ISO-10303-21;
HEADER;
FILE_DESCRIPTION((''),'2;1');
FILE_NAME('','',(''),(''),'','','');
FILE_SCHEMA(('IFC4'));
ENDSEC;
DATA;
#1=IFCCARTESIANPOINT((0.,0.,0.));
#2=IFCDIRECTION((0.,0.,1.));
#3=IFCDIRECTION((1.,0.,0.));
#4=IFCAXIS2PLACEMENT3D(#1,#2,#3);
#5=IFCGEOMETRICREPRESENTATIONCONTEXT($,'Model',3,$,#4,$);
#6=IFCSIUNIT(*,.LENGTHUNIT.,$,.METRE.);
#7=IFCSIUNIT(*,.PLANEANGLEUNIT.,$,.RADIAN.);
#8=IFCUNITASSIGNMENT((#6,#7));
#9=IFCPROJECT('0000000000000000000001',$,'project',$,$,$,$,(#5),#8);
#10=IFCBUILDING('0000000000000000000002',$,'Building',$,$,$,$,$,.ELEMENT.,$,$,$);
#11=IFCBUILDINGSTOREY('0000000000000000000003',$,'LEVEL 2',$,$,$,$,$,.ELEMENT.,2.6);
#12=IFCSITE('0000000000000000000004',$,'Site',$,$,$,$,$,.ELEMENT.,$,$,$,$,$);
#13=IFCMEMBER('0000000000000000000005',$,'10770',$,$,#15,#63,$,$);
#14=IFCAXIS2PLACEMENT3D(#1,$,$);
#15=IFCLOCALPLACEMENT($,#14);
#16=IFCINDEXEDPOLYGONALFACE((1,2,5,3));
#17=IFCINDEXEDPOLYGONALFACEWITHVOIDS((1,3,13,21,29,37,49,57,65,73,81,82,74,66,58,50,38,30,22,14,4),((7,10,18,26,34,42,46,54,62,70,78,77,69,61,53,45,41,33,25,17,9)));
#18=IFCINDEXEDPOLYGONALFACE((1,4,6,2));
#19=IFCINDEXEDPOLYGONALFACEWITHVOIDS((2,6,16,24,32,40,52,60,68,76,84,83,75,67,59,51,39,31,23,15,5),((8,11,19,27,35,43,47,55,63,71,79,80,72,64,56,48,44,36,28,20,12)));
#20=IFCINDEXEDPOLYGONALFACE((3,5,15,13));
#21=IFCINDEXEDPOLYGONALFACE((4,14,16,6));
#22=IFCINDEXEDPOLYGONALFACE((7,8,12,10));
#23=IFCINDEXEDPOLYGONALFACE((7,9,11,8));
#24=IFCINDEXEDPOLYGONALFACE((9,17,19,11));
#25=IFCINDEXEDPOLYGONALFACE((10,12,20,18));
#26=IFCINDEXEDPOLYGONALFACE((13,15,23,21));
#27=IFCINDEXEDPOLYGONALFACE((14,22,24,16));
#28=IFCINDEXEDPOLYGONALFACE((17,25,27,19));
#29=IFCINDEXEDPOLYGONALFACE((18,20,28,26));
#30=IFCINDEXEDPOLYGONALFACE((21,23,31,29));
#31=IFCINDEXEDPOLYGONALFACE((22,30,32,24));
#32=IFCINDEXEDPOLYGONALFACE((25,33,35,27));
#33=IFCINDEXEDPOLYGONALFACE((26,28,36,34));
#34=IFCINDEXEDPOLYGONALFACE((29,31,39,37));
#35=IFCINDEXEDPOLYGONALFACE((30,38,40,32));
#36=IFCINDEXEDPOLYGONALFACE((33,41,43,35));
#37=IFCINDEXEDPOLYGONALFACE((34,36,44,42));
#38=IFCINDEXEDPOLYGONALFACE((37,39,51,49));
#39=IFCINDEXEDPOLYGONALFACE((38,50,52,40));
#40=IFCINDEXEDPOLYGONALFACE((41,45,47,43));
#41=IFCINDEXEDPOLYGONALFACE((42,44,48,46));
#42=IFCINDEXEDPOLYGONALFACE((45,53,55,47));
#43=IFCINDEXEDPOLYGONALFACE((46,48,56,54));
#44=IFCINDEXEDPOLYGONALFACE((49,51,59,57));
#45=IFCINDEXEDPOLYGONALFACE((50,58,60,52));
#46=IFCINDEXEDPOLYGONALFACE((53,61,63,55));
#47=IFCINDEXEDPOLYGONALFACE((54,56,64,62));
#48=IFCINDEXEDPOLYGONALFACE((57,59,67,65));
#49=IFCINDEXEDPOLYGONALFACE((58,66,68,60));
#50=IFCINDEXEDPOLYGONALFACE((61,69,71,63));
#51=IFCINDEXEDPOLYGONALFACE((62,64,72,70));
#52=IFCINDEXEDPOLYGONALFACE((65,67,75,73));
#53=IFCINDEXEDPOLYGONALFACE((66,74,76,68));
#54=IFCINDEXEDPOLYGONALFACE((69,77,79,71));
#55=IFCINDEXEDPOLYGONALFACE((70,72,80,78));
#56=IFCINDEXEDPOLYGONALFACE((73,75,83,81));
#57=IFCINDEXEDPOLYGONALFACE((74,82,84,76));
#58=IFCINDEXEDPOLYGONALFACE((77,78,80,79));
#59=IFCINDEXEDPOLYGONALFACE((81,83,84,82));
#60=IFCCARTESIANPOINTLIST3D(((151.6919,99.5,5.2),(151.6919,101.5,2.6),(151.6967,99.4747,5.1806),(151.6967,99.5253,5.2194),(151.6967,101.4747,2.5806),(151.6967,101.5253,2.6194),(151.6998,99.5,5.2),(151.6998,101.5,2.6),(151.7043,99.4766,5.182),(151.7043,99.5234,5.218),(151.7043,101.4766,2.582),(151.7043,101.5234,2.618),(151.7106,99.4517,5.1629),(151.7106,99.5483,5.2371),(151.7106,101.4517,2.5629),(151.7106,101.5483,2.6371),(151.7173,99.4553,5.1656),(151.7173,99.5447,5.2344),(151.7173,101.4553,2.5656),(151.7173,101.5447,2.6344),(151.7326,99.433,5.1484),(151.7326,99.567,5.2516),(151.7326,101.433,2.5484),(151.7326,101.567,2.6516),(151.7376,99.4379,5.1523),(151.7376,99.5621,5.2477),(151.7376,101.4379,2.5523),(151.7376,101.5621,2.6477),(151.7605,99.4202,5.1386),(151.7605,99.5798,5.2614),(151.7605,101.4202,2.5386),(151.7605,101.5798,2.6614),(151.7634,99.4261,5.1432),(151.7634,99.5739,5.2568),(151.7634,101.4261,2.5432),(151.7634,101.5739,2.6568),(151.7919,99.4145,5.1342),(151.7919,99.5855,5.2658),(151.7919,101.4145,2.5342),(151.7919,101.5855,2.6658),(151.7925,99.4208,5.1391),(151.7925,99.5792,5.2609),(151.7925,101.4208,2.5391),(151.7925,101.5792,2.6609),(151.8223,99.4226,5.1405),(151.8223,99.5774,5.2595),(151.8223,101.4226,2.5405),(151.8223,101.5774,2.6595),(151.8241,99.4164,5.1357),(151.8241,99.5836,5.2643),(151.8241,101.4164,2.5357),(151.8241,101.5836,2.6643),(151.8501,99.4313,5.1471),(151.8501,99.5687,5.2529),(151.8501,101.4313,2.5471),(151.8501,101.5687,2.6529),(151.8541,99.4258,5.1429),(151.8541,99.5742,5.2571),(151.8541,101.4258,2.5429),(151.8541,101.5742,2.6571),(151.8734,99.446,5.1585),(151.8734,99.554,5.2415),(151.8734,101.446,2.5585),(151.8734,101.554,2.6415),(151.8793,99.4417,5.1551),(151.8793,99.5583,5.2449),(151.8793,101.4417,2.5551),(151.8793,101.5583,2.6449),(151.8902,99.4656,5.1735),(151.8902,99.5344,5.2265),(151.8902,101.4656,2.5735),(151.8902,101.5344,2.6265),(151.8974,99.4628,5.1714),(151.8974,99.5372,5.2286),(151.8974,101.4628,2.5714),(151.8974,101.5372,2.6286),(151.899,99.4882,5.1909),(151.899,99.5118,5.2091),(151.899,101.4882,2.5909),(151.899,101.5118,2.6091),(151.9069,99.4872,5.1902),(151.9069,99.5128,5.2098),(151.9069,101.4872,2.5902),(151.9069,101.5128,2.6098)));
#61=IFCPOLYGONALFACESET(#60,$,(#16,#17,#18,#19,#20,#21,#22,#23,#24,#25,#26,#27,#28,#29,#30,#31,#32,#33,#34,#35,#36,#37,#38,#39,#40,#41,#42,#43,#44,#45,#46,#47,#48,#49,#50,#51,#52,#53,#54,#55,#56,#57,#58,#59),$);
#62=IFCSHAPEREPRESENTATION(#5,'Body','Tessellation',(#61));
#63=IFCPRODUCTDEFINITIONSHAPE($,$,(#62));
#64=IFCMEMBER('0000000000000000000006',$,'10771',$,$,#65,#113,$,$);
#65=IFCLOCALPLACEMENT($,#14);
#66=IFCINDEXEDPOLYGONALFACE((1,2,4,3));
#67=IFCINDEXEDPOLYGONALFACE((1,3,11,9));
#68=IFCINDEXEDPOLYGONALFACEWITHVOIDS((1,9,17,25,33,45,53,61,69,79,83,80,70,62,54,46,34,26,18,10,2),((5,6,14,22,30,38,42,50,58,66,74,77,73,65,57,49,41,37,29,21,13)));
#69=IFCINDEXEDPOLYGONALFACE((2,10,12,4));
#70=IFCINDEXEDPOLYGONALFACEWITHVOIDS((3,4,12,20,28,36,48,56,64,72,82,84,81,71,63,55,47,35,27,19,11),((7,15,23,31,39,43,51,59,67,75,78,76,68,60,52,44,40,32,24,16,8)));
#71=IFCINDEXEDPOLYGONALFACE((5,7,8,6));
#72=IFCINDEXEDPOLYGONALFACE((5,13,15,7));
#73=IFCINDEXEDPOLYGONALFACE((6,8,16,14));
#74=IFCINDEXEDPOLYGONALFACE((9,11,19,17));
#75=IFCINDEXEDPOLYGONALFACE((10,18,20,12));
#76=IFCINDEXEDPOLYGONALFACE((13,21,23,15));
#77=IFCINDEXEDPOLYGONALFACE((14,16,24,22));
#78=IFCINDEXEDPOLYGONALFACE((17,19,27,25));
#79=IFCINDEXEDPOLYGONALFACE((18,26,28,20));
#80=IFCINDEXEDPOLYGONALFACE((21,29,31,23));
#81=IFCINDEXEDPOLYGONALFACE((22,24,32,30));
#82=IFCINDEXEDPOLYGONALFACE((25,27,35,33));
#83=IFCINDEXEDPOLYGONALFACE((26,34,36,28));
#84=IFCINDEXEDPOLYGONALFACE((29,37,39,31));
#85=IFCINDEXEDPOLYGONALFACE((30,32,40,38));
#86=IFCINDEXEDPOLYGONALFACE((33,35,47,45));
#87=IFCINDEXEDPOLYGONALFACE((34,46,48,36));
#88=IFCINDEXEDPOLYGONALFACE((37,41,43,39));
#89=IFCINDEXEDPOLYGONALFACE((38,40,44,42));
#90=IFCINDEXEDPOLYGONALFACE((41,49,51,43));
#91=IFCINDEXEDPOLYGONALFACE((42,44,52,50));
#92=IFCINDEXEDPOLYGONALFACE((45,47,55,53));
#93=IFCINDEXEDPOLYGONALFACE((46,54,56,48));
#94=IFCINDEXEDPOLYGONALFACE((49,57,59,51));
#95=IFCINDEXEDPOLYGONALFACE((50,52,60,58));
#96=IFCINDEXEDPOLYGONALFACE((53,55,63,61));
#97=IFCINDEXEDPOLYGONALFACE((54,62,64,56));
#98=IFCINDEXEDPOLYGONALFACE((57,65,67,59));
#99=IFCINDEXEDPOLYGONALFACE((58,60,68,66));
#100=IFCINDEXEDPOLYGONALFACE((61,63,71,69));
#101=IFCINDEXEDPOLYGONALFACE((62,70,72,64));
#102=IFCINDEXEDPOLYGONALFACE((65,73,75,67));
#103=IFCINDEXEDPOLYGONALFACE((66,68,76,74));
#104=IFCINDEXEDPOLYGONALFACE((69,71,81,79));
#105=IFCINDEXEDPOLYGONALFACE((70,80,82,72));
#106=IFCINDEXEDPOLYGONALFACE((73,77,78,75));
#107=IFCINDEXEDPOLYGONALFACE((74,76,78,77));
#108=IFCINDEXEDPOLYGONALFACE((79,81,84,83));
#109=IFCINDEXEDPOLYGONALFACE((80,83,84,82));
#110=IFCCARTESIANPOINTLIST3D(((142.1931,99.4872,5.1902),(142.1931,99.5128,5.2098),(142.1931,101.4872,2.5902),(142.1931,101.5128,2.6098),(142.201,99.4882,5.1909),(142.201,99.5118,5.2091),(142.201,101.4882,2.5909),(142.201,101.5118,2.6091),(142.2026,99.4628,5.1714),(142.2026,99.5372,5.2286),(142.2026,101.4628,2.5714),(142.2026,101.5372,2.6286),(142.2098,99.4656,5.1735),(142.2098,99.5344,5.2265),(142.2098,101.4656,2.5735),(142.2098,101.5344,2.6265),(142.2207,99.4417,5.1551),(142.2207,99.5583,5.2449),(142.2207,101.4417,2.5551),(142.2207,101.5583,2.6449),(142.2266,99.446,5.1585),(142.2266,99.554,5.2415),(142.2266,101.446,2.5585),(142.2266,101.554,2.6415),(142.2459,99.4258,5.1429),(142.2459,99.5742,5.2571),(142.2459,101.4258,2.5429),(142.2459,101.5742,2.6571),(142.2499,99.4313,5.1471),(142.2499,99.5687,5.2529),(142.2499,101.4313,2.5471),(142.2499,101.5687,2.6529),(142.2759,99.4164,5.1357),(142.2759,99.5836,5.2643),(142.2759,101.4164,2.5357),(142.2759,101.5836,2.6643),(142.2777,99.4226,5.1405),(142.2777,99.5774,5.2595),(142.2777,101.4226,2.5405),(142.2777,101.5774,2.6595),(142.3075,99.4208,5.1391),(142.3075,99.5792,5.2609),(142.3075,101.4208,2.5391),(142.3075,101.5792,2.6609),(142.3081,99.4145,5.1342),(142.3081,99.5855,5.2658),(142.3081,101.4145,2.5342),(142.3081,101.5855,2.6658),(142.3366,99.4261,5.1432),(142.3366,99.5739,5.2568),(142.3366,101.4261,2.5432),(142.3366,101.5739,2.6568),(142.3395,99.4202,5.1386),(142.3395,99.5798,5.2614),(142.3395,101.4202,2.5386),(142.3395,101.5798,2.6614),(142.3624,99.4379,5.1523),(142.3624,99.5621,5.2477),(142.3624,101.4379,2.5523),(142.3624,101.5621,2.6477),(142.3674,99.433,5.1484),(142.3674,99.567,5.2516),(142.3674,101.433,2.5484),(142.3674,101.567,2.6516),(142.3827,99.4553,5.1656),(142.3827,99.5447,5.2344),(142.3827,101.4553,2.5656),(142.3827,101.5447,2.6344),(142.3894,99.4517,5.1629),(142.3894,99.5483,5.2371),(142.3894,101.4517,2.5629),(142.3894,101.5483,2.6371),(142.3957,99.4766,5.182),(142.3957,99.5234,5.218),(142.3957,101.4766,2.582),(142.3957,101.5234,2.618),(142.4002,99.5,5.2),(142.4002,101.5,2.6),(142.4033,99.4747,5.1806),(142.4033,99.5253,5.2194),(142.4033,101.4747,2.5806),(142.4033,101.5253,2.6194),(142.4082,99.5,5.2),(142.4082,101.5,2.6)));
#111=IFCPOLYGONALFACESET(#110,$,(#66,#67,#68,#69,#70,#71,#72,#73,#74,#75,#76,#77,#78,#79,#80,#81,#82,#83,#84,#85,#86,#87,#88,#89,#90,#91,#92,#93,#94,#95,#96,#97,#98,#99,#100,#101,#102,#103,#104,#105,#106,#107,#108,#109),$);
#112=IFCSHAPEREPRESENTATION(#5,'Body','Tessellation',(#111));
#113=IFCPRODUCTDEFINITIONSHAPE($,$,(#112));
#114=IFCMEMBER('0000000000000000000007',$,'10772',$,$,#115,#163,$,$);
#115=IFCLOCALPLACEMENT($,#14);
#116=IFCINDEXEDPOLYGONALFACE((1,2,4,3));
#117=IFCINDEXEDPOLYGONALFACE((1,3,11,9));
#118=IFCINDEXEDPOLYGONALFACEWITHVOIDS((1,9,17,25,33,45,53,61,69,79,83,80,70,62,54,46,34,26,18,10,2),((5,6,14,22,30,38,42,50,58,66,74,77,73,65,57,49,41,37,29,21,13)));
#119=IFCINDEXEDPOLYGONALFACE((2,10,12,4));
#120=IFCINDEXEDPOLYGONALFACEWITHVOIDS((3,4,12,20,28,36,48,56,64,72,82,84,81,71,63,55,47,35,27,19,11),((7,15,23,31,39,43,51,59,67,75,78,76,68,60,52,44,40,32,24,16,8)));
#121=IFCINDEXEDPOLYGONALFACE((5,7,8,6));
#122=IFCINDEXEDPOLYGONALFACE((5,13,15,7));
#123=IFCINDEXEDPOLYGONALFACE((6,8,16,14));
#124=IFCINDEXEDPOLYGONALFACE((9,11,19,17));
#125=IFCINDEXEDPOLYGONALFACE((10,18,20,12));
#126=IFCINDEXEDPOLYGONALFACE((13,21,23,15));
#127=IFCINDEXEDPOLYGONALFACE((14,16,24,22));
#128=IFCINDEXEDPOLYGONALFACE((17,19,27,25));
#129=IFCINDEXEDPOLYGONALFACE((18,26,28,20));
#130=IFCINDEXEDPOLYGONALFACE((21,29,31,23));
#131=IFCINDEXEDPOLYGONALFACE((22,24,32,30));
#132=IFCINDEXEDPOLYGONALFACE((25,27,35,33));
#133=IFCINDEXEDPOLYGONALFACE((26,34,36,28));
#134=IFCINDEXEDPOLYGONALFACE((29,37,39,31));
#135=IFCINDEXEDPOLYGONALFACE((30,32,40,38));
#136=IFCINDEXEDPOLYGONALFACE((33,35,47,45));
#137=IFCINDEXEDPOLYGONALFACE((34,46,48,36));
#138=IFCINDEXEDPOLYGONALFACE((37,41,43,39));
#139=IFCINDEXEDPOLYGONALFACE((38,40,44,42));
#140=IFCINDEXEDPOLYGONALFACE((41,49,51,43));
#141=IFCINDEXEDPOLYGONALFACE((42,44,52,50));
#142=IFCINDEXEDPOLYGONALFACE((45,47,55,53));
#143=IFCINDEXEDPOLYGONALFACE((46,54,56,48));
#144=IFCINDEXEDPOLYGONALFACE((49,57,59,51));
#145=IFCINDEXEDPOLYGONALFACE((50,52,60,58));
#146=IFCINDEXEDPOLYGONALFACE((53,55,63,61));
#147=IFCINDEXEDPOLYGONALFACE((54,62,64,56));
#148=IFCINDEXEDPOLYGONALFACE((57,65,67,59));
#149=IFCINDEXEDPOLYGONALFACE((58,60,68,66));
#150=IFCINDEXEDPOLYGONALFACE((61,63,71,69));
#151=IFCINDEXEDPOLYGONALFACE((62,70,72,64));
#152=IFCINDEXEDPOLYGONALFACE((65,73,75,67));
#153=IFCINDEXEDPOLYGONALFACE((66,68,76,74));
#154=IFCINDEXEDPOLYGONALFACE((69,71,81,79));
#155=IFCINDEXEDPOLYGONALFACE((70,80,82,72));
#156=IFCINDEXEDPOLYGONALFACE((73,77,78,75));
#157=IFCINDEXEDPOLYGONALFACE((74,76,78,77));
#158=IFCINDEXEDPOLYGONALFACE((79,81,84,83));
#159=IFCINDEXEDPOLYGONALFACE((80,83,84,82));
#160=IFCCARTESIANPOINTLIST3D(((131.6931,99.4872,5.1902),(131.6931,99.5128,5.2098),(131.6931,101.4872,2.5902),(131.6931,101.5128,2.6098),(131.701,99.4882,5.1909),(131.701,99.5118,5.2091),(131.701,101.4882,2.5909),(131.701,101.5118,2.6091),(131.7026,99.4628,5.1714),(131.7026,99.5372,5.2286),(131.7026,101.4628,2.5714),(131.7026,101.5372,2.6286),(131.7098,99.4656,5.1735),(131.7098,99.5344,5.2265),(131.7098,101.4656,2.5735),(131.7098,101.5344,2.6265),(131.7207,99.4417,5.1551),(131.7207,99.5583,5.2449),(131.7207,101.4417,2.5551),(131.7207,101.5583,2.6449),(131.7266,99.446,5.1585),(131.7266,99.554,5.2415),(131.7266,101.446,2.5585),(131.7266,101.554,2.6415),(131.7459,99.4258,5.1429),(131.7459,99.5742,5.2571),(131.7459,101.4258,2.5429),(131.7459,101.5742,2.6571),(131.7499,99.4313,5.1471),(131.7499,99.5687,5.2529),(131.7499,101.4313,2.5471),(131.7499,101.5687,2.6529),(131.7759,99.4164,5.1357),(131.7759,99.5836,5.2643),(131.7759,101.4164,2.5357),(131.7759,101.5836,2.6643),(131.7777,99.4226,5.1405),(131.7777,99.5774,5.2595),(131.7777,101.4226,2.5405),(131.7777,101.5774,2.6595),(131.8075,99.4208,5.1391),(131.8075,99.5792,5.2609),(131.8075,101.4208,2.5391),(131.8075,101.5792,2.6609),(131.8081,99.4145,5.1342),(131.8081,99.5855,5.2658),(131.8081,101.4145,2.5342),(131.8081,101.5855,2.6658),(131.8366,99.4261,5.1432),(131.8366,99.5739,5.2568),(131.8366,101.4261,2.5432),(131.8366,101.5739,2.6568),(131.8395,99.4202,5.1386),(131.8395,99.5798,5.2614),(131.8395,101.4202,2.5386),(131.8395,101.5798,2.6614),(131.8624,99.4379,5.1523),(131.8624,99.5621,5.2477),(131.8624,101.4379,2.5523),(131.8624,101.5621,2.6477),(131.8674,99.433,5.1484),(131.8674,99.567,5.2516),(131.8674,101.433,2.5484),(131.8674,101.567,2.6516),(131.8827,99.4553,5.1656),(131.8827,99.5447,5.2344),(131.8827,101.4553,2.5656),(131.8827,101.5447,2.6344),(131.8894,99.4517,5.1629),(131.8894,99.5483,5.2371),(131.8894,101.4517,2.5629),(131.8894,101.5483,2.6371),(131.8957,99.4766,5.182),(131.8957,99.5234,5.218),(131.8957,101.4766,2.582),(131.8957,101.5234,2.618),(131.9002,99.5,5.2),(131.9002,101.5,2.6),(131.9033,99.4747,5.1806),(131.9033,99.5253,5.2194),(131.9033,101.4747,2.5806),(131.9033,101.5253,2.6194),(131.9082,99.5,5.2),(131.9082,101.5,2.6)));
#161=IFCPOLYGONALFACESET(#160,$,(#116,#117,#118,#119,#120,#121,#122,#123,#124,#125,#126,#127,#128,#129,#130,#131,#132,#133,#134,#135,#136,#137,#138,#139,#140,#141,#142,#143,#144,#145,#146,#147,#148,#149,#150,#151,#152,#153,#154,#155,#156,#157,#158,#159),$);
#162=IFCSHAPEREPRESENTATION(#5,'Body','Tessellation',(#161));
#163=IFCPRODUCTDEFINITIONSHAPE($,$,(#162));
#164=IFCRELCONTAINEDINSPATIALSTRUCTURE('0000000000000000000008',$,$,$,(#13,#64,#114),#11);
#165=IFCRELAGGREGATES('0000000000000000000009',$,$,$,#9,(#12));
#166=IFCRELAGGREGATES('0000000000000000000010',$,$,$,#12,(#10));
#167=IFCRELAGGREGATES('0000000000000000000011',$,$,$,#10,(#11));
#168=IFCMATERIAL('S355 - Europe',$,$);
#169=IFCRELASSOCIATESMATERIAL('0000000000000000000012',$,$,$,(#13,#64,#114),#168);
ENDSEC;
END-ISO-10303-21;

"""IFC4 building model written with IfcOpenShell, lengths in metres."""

from ifc_helpers import new_model, si_unit, frame, origin_with_axes, origin_2d_with_axis, place, context, project, spatial, hollow_circle, extrude, material, material_profile, profile_set, profile_usage, element, save


model = new_model("IFC4")

# Units and contexts
model_context = context("Model", 3, world=origin_with_axes())
ifc_project = project(units=[si_unit("LENGTHUNIT", "METRE"), si_unit("PLANEANGLEUNIT", "RADIAN")], contexts=[model_context])

# Site, building, storey
site = spatial("IfcSite", under=ifc_project, Name="Site", CompositionType="ELEMENT")
building = spatial("IfcBuilding", under=site, Name="Building", CompositionType="ELEMENT")
storey = spatial("IfcBuildingStorey", under=building, Name="LEVEL 2", CompositionType="ELEMENT", Elevation=2.6)

# Shared definitions
ifc_material = material(Name="S355 - Europe")

# Members
ifc_material_profile_1 = material_profile(ifc_material, hollow_circle(Radius=0.1081, WallThickness=0.008, at=origin_2d_with_axis()))
ifc_profile_set_1 = profile_set([ifc_material_profile_1])
ifc_profile_usage_1 = profile_usage(ifc_profile_set_1, cardinal=10)
member_1_placement = place(None, frame((151.8, 99.5, 5.2), z_axis=(0.0, 0.609711, -0.792624), x_axis=(-1.0, 0.0, 0.0)))
element("IfcMember", 1, at=member_1_placement, inside=storey, material=ifc_profile_usage_1, Name="10770", context=model_context, shape_type="SweptSolid", body=[
    extrude(hollow_circle(Radius=0.1081, WallThickness=0.008, at=origin_2d_with_axis()), origin_with_axes(), (0.0, 0.0, 1.0), 3.2802),
])
ifc_material_profile_2 = material_profile(ifc_material, hollow_circle(Radius=0.1081, WallThickness=0.008, at=origin_2d_with_axis()))
ifc_profile_set_2 = profile_set([ifc_material_profile_2])
ifc_profile_usage_2 = profile_usage(ifc_profile_set_2, cardinal=10)
member_2_placement = place(None, frame((142.3, 101.5, 2.6), z_axis=(0.0, -0.609711, 0.792624), x_axis=(1.0, 0.0, 0.0)))
element("IfcMember", 2, at=member_2_placement, inside=storey, material=ifc_profile_usage_2, Name="10771", context=model_context, shape_type="SweptSolid", body=[
    extrude(hollow_circle(Radius=0.1081, WallThickness=0.008, at=origin_2d_with_axis()), origin_with_axes(), (0.0, 0.0, 1.0), 3.2802),
])
ifc_material_profile_3 = material_profile(ifc_material, hollow_circle(Radius=0.1081, WallThickness=0.008, at=origin_2d_with_axis()))
ifc_profile_set_3 = profile_set([ifc_material_profile_3])
ifc_profile_usage_3 = profile_usage(ifc_profile_set_3, cardinal=10)
member_3_placement = place(None, frame((131.8, 101.5, 2.6), z_axis=(0.0, -0.609711, 0.792624), x_axis=(1.0, 0.0, 0.0)))
element("IfcMember", 3, at=member_3_placement, inside=storey, material=ifc_profile_usage_3, Name="10772", context=model_context, shape_type="SweptSolid", body=[
    extrude(hollow_circle(Radius=0.1081, WallThickness=0.008, at=origin_2d_with_axis()), origin_with_axes(), (0.0, 0.0, 1.0), 3.2802),
])

save(model, "model.ifc")
